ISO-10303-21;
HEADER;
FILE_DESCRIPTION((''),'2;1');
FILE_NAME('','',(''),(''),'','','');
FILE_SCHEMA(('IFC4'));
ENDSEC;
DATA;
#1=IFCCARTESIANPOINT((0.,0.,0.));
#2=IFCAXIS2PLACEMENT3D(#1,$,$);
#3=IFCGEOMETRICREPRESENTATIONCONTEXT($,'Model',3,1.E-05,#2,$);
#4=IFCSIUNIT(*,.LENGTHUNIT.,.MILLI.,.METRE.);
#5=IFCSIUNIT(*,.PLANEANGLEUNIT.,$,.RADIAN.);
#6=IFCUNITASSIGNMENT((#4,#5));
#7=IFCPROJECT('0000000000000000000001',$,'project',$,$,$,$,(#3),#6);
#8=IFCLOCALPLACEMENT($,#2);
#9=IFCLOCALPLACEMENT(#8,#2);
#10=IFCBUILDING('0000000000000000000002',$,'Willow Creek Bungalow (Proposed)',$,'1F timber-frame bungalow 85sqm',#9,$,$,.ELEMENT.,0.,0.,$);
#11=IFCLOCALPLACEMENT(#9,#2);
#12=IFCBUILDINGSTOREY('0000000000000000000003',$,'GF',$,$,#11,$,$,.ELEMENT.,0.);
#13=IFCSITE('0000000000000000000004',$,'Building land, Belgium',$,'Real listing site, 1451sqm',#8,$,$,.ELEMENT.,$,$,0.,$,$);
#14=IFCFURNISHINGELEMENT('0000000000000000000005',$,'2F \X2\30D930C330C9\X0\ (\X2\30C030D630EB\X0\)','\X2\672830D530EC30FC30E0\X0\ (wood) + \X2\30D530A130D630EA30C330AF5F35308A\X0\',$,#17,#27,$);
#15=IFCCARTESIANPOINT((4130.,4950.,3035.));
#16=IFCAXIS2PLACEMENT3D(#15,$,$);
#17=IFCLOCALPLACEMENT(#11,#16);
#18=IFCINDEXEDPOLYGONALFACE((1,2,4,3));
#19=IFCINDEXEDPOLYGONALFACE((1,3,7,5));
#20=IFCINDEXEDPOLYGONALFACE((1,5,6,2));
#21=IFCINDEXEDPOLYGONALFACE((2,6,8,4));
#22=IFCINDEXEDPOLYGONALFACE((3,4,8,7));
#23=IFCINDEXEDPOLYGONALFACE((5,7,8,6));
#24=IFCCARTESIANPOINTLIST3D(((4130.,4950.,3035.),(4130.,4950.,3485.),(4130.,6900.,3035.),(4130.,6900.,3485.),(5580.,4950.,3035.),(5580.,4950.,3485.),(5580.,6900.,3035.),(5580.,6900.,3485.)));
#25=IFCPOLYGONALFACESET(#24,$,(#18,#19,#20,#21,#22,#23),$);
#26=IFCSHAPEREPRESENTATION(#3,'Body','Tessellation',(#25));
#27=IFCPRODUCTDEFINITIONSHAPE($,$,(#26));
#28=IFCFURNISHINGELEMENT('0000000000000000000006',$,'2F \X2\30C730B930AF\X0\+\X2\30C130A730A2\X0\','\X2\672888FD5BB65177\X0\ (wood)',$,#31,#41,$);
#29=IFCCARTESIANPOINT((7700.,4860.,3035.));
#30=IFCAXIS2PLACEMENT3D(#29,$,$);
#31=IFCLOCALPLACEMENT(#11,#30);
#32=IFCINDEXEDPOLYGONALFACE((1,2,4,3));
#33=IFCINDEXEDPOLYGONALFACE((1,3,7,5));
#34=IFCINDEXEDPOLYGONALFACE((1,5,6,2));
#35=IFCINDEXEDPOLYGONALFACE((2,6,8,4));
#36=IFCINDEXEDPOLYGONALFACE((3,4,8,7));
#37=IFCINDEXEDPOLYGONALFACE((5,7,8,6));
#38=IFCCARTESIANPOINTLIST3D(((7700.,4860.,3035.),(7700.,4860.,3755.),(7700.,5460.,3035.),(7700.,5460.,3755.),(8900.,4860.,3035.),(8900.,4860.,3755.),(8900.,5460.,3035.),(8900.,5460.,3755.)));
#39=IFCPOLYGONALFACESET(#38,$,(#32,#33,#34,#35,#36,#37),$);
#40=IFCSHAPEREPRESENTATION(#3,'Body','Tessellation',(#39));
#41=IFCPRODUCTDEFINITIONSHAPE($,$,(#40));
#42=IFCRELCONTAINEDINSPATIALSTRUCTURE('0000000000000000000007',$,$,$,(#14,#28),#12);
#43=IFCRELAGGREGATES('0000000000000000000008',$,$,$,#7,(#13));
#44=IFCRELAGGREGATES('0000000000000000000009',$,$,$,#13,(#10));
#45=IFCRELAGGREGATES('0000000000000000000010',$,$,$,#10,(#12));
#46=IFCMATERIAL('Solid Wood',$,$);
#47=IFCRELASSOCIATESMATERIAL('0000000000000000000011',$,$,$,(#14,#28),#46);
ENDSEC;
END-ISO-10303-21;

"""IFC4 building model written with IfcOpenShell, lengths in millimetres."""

from ifc_helpers import new_model, si_unit, frame, frame_2d, origin, place, context, project, spatial, rectangle, extrude, material, element, save


model = new_model("IFC4")

# Units and contexts
model_context = context("Model", 3, precision=1e-05, world=origin())
ifc_project = project(units=[si_unit("LENGTHUNIT", "METRE", prefix="MILLI"), si_unit("PLANEANGLEUNIT", "RADIAN")], contexts=[model_context])

# Site, building, storey
site_placement = place(None, origin())
site = spatial("IfcSite", under=ifc_project, at=site_placement, Name="Building land, Belgium", ObjectType="Real listing site, 1451sqm", CompositionType="ELEMENT", RefElevation=0.0)
building_placement = place(site_placement, origin())
building = spatial("IfcBuilding", under=site, at=building_placement, Name="Willow Creek Bungalow (Proposed)", ObjectType="1F timber-frame bungalow 85sqm", CompositionType="ELEMENT", ElevationOfRefHeight=0.0, ElevationOfTerrain=0.0)
storey_placement = place(building_placement, origin())
storey = spatial("IfcBuildingStorey", under=building, at=storey_placement, Name="GF", CompositionType="ELEMENT", Elevation=0.0)

# Shared definitions
ifc_material_1 = material(Name="Solid Wood")

# Furnishing elements
furnishing_1_placement = place(storey_placement, frame((4130.0, 4950.0, 3035.0)))
element("IfcFurnishingElement", 1, at=furnishing_1_placement, inside=storey, material=ifc_material_1, Name="2F ベッド (ダブル)", Description="木フレーム (wood) + ファブリック張り", context=model_context, shape_type="SweptSolid", body=[
    extrude(rectangle(XDim=1450.0, YDim=1950.0, at=frame_2d((725.0, 975.0))), frame((4130.0, 4950.0, 3035.0)), (0.0, 0.0, 1.0), 450.0),
])
furnishing_2_placement = place(storey_placement, frame((7700.0, 4860.0, 3035.0)))
element("IfcFurnishingElement", 2, at=furnishing_2_placement, inside=storey, material=ifc_material_1, Name="2F デスク+チェア", Description="木製家具 (wood)", context=model_context, shape_type="SweptSolid", body=[
    extrude(rectangle(XDim=1200.0, YDim=600.0, at=frame_2d((600.0, 300.0))), frame((7700.0, 4860.0, 3035.0)), (0.0, 0.0, 1.0), 720.0),
])

save(model, "model.ifc")
